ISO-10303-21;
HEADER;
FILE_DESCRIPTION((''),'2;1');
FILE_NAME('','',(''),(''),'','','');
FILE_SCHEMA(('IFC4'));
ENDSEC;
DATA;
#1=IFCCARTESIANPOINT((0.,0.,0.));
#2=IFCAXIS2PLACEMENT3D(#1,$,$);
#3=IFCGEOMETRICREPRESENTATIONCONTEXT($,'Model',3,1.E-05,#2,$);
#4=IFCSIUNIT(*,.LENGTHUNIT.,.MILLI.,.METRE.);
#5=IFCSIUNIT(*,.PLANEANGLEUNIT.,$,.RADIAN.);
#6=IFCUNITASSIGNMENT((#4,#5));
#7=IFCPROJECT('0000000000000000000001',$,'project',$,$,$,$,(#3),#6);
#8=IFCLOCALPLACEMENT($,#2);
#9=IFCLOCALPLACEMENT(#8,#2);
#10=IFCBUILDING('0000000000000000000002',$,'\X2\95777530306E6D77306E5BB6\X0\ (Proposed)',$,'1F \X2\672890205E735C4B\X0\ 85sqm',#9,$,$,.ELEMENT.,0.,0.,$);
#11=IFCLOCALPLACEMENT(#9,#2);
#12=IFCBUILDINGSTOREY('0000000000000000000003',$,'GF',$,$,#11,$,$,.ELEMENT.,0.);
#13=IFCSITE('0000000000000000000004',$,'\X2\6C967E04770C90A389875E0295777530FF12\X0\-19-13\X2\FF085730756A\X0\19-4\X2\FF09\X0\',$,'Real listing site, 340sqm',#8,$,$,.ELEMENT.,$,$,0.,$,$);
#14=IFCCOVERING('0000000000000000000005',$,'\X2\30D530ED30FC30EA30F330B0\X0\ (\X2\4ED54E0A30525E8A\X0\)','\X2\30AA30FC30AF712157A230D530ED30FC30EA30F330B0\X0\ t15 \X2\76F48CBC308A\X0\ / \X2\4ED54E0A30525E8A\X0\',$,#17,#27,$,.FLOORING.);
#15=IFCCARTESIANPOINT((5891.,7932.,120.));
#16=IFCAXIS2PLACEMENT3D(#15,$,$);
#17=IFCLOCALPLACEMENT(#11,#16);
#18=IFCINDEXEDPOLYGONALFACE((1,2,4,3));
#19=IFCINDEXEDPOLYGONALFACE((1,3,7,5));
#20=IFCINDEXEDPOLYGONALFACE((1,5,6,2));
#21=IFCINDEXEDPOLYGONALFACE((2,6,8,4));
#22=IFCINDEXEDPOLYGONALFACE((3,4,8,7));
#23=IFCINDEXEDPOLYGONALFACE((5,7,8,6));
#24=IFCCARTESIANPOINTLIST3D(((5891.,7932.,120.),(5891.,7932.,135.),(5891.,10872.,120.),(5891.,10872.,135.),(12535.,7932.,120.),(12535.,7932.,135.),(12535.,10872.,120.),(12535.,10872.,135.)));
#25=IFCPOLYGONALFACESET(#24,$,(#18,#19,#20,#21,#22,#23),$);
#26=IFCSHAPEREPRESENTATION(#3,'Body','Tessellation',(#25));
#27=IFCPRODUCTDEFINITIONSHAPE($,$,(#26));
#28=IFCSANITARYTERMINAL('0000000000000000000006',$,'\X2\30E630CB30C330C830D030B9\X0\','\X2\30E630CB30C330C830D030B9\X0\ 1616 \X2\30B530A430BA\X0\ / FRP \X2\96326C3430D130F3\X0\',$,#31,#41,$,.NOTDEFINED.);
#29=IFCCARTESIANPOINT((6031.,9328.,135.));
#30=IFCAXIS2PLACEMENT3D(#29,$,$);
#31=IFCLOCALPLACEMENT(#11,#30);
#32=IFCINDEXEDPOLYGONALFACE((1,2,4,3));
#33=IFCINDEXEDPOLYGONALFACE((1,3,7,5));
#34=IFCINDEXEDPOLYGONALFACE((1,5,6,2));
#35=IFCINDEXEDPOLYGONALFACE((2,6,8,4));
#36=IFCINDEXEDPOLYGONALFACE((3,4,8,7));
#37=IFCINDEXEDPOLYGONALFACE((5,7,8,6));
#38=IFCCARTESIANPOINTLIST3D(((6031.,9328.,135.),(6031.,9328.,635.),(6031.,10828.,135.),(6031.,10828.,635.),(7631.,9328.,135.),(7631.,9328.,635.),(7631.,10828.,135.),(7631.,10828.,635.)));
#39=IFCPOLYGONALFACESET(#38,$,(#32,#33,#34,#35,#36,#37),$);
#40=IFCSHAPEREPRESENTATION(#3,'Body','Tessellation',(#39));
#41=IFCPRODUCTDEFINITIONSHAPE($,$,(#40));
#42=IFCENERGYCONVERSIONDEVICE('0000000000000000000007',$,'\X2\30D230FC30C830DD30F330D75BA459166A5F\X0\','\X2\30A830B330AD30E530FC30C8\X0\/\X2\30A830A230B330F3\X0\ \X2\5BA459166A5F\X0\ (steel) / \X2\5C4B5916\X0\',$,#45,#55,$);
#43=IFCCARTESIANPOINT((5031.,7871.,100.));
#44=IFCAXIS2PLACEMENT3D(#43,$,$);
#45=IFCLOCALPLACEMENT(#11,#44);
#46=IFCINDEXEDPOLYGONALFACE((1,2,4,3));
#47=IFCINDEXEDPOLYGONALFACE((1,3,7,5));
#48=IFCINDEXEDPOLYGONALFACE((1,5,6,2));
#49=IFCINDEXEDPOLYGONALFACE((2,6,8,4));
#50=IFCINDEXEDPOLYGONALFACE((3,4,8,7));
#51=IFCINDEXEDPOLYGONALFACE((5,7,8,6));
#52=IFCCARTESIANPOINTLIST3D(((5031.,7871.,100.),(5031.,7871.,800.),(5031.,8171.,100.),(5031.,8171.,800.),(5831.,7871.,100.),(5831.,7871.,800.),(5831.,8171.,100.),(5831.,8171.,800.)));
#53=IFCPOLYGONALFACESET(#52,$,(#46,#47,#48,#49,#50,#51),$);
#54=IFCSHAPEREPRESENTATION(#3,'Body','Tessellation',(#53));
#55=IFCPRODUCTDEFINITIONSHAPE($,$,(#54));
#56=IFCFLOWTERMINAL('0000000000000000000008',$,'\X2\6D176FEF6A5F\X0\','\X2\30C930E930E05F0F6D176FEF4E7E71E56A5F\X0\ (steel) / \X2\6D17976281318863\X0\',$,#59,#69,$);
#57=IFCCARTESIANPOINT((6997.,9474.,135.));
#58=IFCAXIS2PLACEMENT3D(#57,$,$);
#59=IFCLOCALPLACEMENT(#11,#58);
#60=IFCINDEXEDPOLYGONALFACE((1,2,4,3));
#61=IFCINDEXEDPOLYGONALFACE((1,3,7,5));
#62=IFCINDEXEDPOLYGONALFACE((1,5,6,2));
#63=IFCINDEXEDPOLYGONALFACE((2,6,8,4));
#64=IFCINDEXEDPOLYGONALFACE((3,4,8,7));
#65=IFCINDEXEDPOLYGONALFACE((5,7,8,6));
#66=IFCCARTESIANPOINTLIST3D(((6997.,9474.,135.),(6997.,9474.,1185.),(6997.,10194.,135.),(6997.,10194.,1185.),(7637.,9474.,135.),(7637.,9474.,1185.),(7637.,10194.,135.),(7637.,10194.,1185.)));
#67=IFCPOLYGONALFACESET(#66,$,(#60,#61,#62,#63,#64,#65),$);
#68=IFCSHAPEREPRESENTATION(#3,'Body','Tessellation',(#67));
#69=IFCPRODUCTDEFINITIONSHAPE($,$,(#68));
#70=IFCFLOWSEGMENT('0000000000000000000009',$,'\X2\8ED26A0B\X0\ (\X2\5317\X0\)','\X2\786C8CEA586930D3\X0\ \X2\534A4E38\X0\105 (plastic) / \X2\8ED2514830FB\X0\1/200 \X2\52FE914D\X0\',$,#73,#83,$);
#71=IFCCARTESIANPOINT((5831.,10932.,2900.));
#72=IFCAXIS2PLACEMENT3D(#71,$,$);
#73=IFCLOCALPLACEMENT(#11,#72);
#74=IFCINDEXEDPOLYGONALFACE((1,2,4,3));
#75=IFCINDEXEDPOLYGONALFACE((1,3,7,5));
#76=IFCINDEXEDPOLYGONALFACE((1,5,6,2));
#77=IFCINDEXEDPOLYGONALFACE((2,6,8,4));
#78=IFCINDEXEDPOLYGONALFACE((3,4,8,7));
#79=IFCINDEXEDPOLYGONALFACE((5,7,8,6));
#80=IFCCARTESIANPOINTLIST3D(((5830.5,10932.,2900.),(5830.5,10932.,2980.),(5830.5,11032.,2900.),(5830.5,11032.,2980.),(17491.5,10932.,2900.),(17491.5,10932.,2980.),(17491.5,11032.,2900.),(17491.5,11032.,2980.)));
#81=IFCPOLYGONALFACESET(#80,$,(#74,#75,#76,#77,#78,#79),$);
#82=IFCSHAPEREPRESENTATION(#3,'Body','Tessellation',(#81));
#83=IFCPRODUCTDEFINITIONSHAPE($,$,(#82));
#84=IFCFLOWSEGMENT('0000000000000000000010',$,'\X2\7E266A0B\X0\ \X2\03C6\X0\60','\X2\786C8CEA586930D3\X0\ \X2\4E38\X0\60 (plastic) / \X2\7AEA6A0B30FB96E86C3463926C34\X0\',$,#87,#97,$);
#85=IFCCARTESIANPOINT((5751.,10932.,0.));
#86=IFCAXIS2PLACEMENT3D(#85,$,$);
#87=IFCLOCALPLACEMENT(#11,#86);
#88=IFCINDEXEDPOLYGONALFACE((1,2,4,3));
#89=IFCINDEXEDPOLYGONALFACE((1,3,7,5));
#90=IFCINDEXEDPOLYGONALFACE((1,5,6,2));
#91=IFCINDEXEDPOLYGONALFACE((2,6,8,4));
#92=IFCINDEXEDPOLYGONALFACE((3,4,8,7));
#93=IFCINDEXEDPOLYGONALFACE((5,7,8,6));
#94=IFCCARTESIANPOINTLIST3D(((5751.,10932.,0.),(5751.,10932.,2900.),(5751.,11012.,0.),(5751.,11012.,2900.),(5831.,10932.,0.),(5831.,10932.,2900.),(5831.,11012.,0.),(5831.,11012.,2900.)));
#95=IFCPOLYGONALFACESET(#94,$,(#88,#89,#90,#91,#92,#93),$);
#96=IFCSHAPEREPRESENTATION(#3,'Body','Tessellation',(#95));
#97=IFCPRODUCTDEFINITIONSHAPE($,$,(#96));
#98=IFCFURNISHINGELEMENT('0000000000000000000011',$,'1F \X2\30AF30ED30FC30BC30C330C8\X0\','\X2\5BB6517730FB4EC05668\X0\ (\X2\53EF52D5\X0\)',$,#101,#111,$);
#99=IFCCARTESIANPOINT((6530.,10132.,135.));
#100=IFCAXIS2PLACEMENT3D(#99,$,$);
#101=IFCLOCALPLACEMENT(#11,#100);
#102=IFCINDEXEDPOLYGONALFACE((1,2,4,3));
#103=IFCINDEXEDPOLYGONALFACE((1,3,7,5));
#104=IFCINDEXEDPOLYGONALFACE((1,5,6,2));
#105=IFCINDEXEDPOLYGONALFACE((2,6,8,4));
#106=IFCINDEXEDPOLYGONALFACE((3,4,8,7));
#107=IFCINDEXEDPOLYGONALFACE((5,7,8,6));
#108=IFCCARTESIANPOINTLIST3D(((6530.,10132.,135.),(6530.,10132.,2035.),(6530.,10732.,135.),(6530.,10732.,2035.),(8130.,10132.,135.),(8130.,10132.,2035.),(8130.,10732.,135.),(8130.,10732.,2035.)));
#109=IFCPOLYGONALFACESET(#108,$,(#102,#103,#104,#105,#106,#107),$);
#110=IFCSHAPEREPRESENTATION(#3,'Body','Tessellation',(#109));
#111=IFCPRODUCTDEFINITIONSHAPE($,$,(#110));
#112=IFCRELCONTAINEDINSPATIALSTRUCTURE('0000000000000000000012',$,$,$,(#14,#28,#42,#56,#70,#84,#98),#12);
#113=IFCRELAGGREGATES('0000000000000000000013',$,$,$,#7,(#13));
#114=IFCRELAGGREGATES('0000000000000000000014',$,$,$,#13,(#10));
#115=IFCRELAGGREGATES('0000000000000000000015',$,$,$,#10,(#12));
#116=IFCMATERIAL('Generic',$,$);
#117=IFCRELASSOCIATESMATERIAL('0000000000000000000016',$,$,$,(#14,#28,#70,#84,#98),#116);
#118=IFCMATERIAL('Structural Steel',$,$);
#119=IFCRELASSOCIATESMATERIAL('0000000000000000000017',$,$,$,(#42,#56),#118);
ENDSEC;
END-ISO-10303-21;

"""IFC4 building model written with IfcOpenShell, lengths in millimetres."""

from ifc_helpers import new_model, si_unit, frame, frame_2d, origin, place, context, project, spatial, rectangle, extrude, material, element, save


model = new_model("IFC4")

# Units and contexts
model_context = context("Model", 3, precision=1e-05, world=origin())
ifc_project = project(units=[si_unit("LENGTHUNIT", "METRE", prefix="MILLI"), si_unit("PLANEANGLEUNIT", "RADIAN")], contexts=[model_context])

# Site, building, storey
site_placement = place(None, origin())
site = spatial("IfcSite", under=ifc_project, at=site_placement, Name="沖縄県那覇市長田２-19-13（地番19-4）", ObjectType="Real listing site, 340sqm", CompositionType="ELEMENT", RefElevation=0.0)
building_placement = place(site_placement, origin())
building = spatial("IfcBuilding", under=site, at=building_placement, Name="長田の海の家 (Proposed)", ObjectType="1F 木造平屋 85sqm", CompositionType="ELEMENT", ElevationOfRefHeight=0.0, ElevationOfTerrain=0.0)
storey_placement = place(building_placement, origin())
storey = spatial("IfcBuildingStorey", under=building, at=storey_placement, Name="GF", CompositionType="ELEMENT", Elevation=0.0)

# Shared definitions
ifc_material_1 = material(Name="Structural Steel")

# Covering
ifc_material_2 = material(Name="Generic")
covering_placement = place(storey_placement, frame((5891.0, 7932.0, 120.0)))
element("IfcCovering", 1, at=covering_placement, inside=storey, material=ifc_material_2, Name="フローリング (仕上げ床)", Description="オーク無垢フローリング t15 直貼り / 仕上げ床", PredefinedType="FLOORING", context=model_context, shape_type="SweptSolid", body=[
    extrude(rectangle(XDim=6644.0, YDim=2940.0, at=frame_2d((3322.0, 1470.0))), frame((5891.0, 7932.0, 120.0)), (0.0, 0.0, 1.0), 15.0),
])

# Sanitary terminal
sanitary_terminal_placement = place(storey_placement, frame((6031.0, 9328.0, 135.0)))
element("IfcSanitaryTerminal", 2, at=sanitary_terminal_placement, inside=storey, material=ifc_material_2, Name="ユニットバス", Description="ユニットバス 1616 サイズ / FRP 防水パン", PredefinedType="NOTDEFINED", context=model_context, shape_type="SweptSolid", body=[
    extrude(rectangle(XDim=1600.0, YDim=1500.0, at=frame_2d((800.0, 750.0))), frame((6031.0, 9328.0, 135.0)), (0.0, 0.0, 1.0), 500.0),
])

# Energy conversion device
energy_conversion_device_placement = place(storey_placement, frame((5031.0, 7871.0, 100.0)))
element("IfcEnergyConversionDevice", 3, at=energy_conversion_device_placement, inside=storey, material=ifc_material_1, Name="ヒートポンプ室外機", Description="エコキュート/エアコン 室外機 (steel) / 屋外", context=model_context, shape_type="SweptSolid", body=[
    extrude(rectangle(XDim=800.0, YDim=300.0, at=frame_2d((400.0, 150.0))), frame((5031.0, 7871.0, 100.0)), (0.0, 0.0, 1.0), 700.0),
])

# Flow terminal
flow_terminal_placement = place(storey_placement, frame((6997.0, 9474.0, 135.0)))
element("IfcFlowTerminal", 4, at=flow_terminal_placement, inside=storey, material=ifc_material_1, Name="洗濯機", Description="ドラム式洗濯乾燥機 (steel) / 洗面脱衣", context=model_context, shape_type="SweptSolid", body=[
    extrude(rectangle(XDim=640.0, YDim=720.0, at=frame_2d((320.0, 360.0))), frame((6997.0, 9474.0, 135.0)), (0.0, 0.0, 1.0), 1050.0),
])

# Flow segments
flow_segment_1_placement = place(storey_placement, frame((5831.0, 10932.0, 2900.0)))
element("IfcFlowSegment", 5, at=flow_segment_1_placement, inside=storey, material=ifc_material_2, Name="軒樋 (北)", Description="硬質塩ビ 半丸105 (plastic) / 軒先・1/200 勾配", context=model_context, shape_type="SweptSolid", body=[
    extrude(rectangle(XDim=11661.0, YDim=100.0, at=frame_2d((5830.0, 50.0))), frame((5831.0, 10932.0, 2900.0)), (0.0, 0.0, 1.0), 80.0),
])
flow_segment_2_placement = place(storey_placement, frame((5751.0, 10932.0, 0.0)))
element("IfcFlowSegment", 6, at=flow_segment_2_placement, inside=storey, material=ifc_material_2, Name="縦樋 φ60", Description="硬質塩ビ 丸60 (plastic) / 竪樋・雨水排水", context=model_context, shape_type="SweptSolid", body=[
    extrude(rectangle(XDim=80.0, YDim=80.0, at=frame_2d((40.0, 40.0))), frame((5751.0, 10932.0, 0.0)), (0.0, 0.0, 1.0), 2900.0),
])

# Furnishing element
furnishing_placement = place(storey_placement, frame((6530.0, 10132.0, 135.0)))
element("IfcFurnishingElement", 7, at=furnishing_placement, inside=storey, material=ifc_material_2, Name="1F クローゼット", Description="家具・什器 (可動)", context=model_context, shape_type="SweptSolid", body=[
    extrude(rectangle(XDim=1600.0, YDim=600.0, at=frame_2d((800.0, 300.0))), frame((6530.0, 10132.0, 135.0)), (0.0, 0.0, 1.0), 1900.0),
])

save(model, "model.ifc")
